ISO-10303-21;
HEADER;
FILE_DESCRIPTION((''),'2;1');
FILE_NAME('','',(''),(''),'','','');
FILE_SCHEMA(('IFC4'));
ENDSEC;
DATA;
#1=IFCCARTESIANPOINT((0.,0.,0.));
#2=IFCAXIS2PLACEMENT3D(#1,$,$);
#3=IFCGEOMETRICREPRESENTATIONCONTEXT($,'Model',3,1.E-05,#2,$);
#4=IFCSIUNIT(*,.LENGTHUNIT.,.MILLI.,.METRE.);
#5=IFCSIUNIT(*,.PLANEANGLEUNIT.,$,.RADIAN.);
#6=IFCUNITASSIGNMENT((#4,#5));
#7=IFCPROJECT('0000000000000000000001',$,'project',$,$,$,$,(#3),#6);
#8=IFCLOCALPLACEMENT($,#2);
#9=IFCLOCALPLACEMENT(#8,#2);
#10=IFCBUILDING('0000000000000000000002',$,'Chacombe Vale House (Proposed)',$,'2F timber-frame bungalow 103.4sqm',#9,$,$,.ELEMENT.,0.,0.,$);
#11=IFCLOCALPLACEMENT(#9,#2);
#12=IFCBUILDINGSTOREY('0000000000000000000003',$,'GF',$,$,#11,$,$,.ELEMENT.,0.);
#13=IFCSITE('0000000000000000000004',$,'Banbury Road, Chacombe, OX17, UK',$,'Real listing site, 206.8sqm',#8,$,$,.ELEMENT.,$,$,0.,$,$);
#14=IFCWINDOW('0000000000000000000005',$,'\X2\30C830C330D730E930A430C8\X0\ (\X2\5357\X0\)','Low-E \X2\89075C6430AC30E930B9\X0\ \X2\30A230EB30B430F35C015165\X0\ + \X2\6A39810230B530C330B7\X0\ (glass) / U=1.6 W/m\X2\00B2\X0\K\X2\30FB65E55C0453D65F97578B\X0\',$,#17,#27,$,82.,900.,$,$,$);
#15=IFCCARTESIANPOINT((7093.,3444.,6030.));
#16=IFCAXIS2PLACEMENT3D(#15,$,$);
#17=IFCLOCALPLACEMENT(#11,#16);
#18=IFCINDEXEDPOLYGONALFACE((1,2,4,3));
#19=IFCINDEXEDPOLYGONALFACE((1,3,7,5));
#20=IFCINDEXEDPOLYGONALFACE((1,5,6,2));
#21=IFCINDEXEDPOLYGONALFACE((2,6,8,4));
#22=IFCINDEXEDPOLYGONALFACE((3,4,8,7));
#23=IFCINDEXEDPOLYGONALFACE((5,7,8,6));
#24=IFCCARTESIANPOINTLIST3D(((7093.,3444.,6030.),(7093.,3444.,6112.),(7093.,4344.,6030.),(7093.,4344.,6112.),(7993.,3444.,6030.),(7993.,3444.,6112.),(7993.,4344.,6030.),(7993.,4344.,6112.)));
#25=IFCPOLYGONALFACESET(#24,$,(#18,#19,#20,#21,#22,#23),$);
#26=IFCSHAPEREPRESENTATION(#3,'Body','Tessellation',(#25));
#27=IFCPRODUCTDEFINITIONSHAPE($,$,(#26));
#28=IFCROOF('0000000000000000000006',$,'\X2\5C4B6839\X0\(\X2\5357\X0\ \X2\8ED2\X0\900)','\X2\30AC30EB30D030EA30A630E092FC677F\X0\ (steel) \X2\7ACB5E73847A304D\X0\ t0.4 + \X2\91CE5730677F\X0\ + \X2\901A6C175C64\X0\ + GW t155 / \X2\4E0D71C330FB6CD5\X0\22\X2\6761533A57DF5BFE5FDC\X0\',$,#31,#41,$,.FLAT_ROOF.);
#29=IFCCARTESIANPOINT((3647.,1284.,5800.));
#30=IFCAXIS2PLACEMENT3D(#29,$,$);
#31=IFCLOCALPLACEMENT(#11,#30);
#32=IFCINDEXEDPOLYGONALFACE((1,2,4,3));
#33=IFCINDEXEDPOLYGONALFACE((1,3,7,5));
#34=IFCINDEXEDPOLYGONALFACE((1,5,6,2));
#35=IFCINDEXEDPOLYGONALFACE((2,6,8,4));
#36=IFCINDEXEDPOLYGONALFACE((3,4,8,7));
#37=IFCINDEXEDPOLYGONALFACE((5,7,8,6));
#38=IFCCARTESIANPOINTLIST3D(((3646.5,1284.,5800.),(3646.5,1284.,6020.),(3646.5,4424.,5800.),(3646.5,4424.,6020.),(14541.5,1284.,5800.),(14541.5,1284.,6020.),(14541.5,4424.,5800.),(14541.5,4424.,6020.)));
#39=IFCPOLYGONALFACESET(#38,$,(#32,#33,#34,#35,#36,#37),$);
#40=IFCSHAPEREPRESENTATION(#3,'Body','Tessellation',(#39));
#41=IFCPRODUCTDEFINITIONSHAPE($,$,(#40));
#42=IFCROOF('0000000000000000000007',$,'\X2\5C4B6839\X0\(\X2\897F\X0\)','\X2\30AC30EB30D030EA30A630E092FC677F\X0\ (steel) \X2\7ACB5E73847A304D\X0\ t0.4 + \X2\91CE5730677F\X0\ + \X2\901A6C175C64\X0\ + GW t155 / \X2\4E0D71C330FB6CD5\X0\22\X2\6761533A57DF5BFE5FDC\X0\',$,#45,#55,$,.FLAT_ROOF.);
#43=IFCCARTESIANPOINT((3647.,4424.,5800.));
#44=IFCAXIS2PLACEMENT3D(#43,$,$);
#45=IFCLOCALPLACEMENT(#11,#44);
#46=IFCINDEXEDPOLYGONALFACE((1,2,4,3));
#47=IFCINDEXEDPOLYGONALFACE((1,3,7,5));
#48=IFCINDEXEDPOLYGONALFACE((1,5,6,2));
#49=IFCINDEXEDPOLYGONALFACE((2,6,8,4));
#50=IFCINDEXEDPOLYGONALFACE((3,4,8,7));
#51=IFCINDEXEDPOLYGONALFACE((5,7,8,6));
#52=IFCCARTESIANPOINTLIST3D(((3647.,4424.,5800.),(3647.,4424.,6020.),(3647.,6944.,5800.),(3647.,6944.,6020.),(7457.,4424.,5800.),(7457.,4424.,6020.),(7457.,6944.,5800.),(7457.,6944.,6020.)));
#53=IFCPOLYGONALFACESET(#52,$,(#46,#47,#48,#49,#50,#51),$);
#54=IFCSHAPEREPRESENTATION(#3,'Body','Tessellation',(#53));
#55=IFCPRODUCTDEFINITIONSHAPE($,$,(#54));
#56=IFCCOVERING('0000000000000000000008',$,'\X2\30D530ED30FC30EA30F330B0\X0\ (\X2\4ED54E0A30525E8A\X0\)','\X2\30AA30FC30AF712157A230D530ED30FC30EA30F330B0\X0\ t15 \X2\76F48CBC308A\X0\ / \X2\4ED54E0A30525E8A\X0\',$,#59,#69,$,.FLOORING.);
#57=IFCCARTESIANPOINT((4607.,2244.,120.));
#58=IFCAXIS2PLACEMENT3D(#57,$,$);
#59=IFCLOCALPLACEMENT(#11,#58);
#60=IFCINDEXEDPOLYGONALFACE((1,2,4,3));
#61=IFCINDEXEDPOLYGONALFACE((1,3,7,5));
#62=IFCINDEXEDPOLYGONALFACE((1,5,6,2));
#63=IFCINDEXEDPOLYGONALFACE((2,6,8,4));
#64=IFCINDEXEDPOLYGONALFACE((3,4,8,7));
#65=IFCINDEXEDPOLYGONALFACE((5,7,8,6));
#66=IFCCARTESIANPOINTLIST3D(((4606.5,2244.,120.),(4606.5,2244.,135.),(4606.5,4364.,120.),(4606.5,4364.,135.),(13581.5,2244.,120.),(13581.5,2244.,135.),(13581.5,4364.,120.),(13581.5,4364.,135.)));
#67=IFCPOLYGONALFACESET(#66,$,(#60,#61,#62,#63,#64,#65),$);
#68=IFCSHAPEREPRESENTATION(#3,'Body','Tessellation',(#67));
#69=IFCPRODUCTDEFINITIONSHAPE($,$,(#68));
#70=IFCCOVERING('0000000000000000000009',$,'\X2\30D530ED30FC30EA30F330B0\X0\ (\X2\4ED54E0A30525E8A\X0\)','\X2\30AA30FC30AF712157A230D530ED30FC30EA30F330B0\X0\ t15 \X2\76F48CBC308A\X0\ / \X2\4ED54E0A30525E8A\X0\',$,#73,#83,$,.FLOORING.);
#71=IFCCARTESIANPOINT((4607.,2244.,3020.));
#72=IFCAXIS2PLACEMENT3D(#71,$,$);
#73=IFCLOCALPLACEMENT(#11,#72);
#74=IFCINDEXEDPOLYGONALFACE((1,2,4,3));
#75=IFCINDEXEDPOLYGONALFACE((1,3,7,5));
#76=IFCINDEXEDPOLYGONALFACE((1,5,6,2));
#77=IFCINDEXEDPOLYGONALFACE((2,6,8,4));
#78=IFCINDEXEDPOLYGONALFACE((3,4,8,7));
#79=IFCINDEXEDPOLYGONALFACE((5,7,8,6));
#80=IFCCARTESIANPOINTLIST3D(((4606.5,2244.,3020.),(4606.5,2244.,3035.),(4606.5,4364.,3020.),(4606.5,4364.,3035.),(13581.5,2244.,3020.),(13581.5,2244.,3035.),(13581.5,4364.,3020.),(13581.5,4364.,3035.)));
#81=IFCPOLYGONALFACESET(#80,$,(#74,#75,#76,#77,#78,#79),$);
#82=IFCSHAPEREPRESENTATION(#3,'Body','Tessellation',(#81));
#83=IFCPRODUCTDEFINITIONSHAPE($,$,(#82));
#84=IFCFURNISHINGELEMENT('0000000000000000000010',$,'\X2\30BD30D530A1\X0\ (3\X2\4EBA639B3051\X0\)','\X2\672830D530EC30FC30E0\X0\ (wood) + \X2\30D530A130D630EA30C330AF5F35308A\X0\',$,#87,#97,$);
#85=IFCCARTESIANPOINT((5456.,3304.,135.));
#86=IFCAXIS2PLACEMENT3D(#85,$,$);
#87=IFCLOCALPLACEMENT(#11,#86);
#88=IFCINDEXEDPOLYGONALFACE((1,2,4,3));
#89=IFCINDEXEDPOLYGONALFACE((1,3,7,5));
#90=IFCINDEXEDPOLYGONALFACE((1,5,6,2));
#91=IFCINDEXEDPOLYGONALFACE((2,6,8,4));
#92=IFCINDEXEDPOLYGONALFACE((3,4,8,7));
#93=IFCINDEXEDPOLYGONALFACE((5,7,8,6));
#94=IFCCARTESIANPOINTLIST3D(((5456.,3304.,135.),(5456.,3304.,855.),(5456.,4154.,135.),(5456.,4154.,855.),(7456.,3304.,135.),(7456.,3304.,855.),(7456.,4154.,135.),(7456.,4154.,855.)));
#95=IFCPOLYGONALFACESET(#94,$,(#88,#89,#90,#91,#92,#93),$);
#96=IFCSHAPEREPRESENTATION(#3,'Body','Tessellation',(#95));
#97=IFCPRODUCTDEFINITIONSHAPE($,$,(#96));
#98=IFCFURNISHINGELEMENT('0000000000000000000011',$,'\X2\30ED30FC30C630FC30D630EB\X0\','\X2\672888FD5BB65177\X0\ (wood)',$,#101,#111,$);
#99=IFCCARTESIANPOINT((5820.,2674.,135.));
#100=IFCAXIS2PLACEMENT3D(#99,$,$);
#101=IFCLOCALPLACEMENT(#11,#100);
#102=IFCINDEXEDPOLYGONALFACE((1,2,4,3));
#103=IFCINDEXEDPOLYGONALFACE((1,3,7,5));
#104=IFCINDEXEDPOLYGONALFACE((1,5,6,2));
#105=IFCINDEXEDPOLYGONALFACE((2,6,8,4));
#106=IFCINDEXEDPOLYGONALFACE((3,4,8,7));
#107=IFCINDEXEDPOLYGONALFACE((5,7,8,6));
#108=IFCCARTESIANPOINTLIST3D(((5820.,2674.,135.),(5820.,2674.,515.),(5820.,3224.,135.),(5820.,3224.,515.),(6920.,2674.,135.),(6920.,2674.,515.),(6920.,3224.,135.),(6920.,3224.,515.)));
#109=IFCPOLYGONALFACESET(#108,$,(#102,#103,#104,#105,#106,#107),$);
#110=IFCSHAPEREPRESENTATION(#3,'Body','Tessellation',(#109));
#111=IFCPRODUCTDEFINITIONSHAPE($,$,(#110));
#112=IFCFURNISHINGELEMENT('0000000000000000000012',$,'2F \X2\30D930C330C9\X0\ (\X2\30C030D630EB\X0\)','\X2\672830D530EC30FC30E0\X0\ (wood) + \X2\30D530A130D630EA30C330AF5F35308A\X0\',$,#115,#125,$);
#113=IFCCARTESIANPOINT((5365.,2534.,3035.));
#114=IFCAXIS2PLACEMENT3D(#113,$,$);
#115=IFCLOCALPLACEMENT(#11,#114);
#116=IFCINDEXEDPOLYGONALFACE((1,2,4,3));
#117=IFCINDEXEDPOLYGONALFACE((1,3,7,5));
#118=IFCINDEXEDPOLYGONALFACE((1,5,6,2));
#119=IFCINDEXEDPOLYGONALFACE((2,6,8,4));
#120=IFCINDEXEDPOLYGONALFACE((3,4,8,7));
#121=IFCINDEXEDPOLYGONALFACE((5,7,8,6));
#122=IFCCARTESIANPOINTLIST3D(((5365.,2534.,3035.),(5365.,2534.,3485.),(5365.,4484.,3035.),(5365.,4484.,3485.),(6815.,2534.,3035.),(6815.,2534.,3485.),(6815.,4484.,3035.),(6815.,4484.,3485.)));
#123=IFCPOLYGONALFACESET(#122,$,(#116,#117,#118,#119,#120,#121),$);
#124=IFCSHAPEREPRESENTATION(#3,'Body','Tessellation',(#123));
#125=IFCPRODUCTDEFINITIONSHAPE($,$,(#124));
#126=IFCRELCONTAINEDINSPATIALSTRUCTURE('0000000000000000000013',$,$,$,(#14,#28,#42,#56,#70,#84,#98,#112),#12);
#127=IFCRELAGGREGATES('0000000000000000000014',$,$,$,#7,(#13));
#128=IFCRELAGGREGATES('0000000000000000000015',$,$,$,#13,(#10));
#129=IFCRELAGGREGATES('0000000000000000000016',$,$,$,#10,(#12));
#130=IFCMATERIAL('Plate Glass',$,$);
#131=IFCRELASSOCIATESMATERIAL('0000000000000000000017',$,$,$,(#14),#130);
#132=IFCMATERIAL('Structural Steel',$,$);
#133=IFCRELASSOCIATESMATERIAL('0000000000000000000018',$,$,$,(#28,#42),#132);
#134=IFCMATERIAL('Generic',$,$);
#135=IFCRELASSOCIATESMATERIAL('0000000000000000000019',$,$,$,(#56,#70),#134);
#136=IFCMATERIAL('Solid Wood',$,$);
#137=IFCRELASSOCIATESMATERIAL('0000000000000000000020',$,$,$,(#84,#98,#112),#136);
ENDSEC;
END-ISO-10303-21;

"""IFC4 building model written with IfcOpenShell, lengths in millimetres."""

from ifc_helpers import new_model, si_unit, frame, frame_2d, origin, place, context, project, spatial, rectangle, extrude, material, element, save


model = new_model("IFC4")

# Units and contexts
model_context = context("Model", 3, precision=1e-05, world=origin())
ifc_project = project(units=[si_unit("LENGTHUNIT", "METRE", prefix="MILLI"), si_unit("PLANEANGLEUNIT", "RADIAN")], contexts=[model_context])

# Site, building, storey
site_placement = place(None, origin())
site = spatial("IfcSite", under=ifc_project, at=site_placement, Name="Banbury Road, Chacombe, OX17, UK", ObjectType="Real listing site, 206.8sqm", CompositionType="ELEMENT", RefElevation=0.0)
building_placement = place(site_placement, origin())
building = spatial("IfcBuilding", under=site, at=building_placement, Name="Chacombe Vale House (Proposed)", ObjectType="2F timber-frame bungalow 103.4sqm", CompositionType="ELEMENT", ElevationOfRefHeight=0.0, ElevationOfTerrain=0.0)
storey_placement = place(building_placement, origin())
storey = spatial("IfcBuildingStorey", under=building, at=storey_placement, Name="GF", CompositionType="ELEMENT", Elevation=0.0)

# Shared definitions
ifc_material_1 = material(Name="Solid Wood")

# Shared definitions
ifc_material_2 = material(Name="Plate Glass")

# Window
window_1_placement = place(storey_placement, frame((7093.0, 3444.0, 6030.0)))
element("IfcWindow", 1, at=window_1_placement, inside=storey, material=ifc_material_2, Name="トップライト (南)", Description="Low-E 複層ガラス アルゴン封入 + 樹脂サッシ (glass) / U=1.6 W/m²K・日射取得型", OverallHeight=82.0, OverallWidth=900.0, context=model_context, shape_type="SweptSolid", body=[
    extrude(rectangle(XDim=900.0, YDim=900.0, at=frame_2d((450.0, 450.0))), frame((7093.0, 3444.0, 6030.0)), (0.0, 0.0, 1.0), 82.0),
])

# Roofs
ifc_material_3 = material(Name="Structural Steel")
roof_1_placement = place(storey_placement, frame((3647.0, 1284.0, 5800.0)))
element("IfcRoof", 2, at=roof_1_placement, inside=storey, material=ifc_material_3, Name="屋根(南 軒900)", Description="ガルバリウム鋼板 (steel) 立平葺き t0.4 + 野地板 + 通気層 + GW t155 / 不燃・法22条区域対応", PredefinedType="FLAT_ROOF", context=model_context, shape_type="SweptSolid", body=[
    extrude(rectangle(XDim=10895.0, YDim=3140.0, at=frame_2d((5447.0, 1570.0))), frame((3647.0, 1284.0, 5800.0)), (0.0, 0.0, 1.0), 220.0),
])
roof_2_placement = place(storey_placement, frame((3647.0, 4424.0, 5800.0)))
element("IfcRoof", 3, at=roof_2_placement, inside=storey, material=ifc_material_3, Name="屋根(西)", Description="ガルバリウム鋼板 (steel) 立平葺き t0.4 + 野地板 + 通気層 + GW t155 / 不燃・法22条区域対応", PredefinedType="FLAT_ROOF", context=model_context, shape_type="SweptSolid", body=[
    extrude(rectangle(XDim=3810.0, YDim=2520.0, at=frame_2d((1905.0, 1260.0))), frame((3647.0, 4424.0, 5800.0)), (0.0, 0.0, 1.0), 220.0),
])

# Coverings
ifc_material_4 = material(Name="Generic")
covering_1_placement = place(storey_placement, frame((4607.0, 2244.0, 120.0)))
element("IfcCovering", 4, at=covering_1_placement, inside=storey, material=ifc_material_4, Name="フローリング (仕上げ床)", Description="オーク無垢フローリング t15 直貼り / 仕上げ床", PredefinedType="FLOORING", context=model_context, shape_type="SweptSolid", body=[
    extrude(rectangle(XDim=8975.0, YDim=2120.0, at=frame_2d((4487.0, 1060.0))), frame((4607.0, 2244.0, 120.0)), (0.0, 0.0, 1.0), 15.0),
])
covering_2_placement = place(storey_placement, frame((4607.0, 2244.0, 3020.0)))
element("IfcCovering", 5, at=covering_2_placement, inside=storey, material=ifc_material_4, Name="フローリング (仕上げ床)", Description="オーク無垢フローリング t15 直貼り / 仕上げ床", PredefinedType="FLOORING", context=model_context, shape_type="SweptSolid", body=[
    extrude(rectangle(XDim=8975.0, YDim=2120.0, at=frame_2d((4487.0, 1060.0))), frame((4607.0, 2244.0, 3020.0)), (0.0, 0.0, 1.0), 15.0),
])

# Furnishing elements
furnishing_1_placement = place(storey_placement, frame((5456.0, 3304.0, 135.0)))
element("IfcFurnishingElement", 6, at=furnishing_1_placement, inside=storey, material=ifc_material_1, Name="ソファ (3人掛け)", Description="木フレーム (wood) + ファブリック張り", context=model_context, shape_type="SweptSolid", body=[
    extrude(rectangle(XDim=2000.0, YDim=850.0, at=frame_2d((1000.0, 425.0))), frame((5456.0, 3304.0, 135.0)), (0.0, 0.0, 1.0), 720.0),
])
furnishing_2_placement = place(storey_placement, frame((5820.0, 2674.0, 135.0)))
element("IfcFurnishingElement", 7, at=furnishing_2_placement, inside=storey, material=ifc_material_1, Name="ローテーブル", Description="木製家具 (wood)", context=model_context, shape_type="SweptSolid", body=[
    extrude(rectangle(XDim=1100.0, YDim=550.0, at=frame_2d((550.0, 275.0))), frame((5820.0, 2674.0, 135.0)), (0.0, 0.0, 1.0), 380.0),
])
furnishing_3_placement = place(storey_placement, frame((5365.0, 2534.0, 3035.0)))
element("IfcFurnishingElement", 8, at=furnishing_3_placement, inside=storey, material=ifc_material_1, Name="2F ベッド (ダブル)", Description="木フレーム (wood) + ファブリック張り", context=model_context, shape_type="SweptSolid", body=[
    extrude(rectangle(XDim=1450.0, YDim=1950.0, at=frame_2d((725.0, 975.0))), frame((5365.0, 2534.0, 3035.0)), (0.0, 0.0, 1.0), 450.0),
])

save(model, "model.ifc")
